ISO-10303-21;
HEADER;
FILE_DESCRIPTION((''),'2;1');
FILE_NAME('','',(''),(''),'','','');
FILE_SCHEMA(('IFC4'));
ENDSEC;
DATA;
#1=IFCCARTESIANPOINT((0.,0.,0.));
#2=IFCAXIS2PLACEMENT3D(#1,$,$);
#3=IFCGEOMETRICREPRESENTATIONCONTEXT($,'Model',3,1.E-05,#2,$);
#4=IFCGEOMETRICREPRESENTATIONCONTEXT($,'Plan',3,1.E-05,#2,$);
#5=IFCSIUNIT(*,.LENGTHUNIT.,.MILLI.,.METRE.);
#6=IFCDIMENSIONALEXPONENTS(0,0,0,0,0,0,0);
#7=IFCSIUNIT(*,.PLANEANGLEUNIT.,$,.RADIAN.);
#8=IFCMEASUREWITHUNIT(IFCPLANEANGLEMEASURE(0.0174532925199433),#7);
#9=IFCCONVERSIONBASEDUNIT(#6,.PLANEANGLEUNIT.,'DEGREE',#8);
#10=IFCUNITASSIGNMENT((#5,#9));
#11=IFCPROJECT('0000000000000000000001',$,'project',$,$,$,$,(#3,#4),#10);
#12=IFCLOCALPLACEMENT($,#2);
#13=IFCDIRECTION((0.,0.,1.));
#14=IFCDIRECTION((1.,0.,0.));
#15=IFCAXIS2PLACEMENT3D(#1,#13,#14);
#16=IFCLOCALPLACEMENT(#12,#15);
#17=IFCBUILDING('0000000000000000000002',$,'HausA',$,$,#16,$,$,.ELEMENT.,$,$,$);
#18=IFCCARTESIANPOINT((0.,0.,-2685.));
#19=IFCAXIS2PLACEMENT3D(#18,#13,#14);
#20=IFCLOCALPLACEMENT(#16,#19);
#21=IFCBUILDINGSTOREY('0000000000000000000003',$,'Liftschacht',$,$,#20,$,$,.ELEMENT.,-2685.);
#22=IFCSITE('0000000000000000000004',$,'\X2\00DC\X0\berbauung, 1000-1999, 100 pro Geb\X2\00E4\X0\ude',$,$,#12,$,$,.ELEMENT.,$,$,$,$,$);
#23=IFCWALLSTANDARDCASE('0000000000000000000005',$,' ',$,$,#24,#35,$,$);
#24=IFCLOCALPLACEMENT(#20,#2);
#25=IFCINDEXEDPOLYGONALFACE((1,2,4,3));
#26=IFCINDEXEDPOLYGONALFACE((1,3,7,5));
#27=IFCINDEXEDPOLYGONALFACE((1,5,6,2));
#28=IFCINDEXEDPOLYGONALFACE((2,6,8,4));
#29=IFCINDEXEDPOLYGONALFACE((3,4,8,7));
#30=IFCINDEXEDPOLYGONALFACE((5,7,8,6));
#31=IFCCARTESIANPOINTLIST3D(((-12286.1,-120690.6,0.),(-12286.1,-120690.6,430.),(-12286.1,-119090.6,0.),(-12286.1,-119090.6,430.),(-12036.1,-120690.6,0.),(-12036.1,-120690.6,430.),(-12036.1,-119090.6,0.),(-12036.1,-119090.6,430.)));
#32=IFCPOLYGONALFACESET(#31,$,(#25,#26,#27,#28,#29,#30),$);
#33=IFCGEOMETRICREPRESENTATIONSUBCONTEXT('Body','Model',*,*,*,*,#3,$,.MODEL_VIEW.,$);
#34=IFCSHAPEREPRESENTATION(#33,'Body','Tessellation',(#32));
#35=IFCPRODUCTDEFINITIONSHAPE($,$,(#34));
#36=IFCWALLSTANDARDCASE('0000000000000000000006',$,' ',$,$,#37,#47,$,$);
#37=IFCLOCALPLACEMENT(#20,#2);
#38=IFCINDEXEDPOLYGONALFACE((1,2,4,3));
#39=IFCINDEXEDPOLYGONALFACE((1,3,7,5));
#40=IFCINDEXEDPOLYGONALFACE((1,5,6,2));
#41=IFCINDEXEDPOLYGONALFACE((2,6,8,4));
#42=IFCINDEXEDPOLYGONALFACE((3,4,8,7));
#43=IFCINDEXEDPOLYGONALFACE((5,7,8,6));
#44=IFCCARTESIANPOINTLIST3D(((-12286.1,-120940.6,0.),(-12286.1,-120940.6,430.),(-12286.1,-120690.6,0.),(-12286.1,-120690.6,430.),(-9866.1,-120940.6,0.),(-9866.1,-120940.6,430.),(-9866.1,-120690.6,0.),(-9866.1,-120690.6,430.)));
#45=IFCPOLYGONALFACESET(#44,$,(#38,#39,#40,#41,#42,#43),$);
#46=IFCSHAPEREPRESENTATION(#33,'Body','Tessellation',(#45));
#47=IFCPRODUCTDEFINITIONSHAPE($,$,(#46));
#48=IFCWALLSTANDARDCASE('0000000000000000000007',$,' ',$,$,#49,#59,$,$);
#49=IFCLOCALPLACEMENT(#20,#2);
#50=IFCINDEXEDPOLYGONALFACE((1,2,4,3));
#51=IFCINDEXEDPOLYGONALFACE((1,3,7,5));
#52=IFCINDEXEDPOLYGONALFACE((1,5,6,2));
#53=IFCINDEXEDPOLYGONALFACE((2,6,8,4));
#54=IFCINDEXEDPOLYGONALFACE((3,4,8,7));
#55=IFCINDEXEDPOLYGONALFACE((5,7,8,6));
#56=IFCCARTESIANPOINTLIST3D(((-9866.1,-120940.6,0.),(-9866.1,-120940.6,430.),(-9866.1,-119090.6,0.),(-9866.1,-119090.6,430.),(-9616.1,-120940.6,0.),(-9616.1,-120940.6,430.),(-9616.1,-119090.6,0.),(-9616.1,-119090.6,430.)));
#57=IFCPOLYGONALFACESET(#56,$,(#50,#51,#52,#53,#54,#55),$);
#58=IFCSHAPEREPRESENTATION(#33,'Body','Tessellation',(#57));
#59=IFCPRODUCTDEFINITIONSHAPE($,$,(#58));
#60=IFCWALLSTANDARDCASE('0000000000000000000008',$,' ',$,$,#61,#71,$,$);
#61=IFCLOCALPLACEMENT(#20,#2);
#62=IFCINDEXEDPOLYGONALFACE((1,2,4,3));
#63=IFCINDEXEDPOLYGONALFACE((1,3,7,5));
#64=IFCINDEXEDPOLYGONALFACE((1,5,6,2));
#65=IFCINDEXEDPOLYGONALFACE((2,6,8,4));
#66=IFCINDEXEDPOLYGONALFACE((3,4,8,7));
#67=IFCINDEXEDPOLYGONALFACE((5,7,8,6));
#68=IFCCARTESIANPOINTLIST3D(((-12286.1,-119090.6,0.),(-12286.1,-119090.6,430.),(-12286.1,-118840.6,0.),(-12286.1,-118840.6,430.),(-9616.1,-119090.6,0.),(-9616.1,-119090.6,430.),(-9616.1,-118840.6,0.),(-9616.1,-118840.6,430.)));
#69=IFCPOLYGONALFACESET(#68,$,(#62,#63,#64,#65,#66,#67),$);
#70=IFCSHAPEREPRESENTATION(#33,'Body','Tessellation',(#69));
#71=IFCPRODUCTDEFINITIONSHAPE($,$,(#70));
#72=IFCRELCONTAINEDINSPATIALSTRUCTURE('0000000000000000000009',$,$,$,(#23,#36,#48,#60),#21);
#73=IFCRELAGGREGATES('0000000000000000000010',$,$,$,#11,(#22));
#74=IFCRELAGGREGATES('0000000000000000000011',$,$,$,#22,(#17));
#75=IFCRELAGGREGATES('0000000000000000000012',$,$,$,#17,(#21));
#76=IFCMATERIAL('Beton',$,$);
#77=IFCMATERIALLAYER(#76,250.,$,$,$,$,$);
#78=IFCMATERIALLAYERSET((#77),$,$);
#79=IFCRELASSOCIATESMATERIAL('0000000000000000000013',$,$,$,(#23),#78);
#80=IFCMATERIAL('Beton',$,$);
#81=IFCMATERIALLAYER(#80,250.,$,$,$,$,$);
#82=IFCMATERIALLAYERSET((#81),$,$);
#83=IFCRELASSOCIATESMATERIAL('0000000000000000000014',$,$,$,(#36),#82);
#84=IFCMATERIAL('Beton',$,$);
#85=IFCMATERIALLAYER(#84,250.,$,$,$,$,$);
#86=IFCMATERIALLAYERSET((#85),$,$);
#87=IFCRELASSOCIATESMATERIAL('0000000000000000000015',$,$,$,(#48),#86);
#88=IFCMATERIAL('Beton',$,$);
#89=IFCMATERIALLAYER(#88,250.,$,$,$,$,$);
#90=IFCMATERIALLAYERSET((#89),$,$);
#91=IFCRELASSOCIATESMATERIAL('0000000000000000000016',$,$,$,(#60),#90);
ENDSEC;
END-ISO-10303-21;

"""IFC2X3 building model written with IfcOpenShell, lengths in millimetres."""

from ifc_helpers import new_model, entity, si_unit, converted_unit, frame, frame_2d, origin, origin_with_axes, place, context, subcontext, project, spatial, rectangle, extrude, material, layer, layer_set, layer_usage, element, save


model = new_model("IFC2X3")

# Units and contexts
model_context = context("Model", 3, precision=1e-05, world=origin())
plan_context = context("Plan", 3, precision=1e-05, world=origin())
body_context = subcontext(model_context, "Body", "Model", "MODEL_VIEW")
ifc_project = project(units=[si_unit("LENGTHUNIT", "METRE", prefix="MILLI"), converted_unit("PLANEANGLEUNIT", "DEGREE", entity("IfcPlaneAngleMeasure", 0.0174532925199433), si_unit("PLANEANGLEUNIT", "RADIAN"), dimensions=[0, 0, 0, 0, 0, 0, 0])], contexts=[model_context, plan_context])

# Site, building, storey
site_placement = place(None, origin())
site = spatial("IfcSite", under=ifc_project, at=site_placement, Name="Überbauung, 1000-1999, 100 pro Gebäude", CompositionType="ELEMENT")
building_placement = place(site_placement, origin_with_axes())
building = spatial("IfcBuilding", under=site, at=building_placement, Name="HausA", CompositionType="ELEMENT")
storey_placement = place(building_placement, frame((0.0, 0.0, -2685.0), z_axis=(0.0, 0.0, 1.0), x_axis=(1.0, 0.0, 0.0)))
storey = spatial("IfcBuildingStorey", under=building, at=storey_placement, Name="Liftschacht", CompositionType="ELEMENT", Elevation=-2685.0)

# Walls
ifc_material_1 = material(Name="Beton")
ifc_layer_1 = layer(ifc_material_1, 250.0)
ifc_layer_set_1 = layer_set([ifc_layer_1])
ifc_layer_usage_1 = layer_usage(ifc_layer_set_1, "AXIS2", "POSITIVE", 0.0)
wall_1_placement = place(storey_placement, frame((-12286.1, -119090.6, 0.0), z_axis=(0.0, 0.0, 1.0), x_axis=(0.0, -1.0, 0.0)))
element("IfcWallStandardCase", 1, at=wall_1_placement, inside=storey, material=ifc_layer_usage_1, Name=" ", context=body_context, shape_type="SweptSolid", body=[
    extrude(rectangle(XDim=1600.0, YDim=250.0, at=frame_2d((800.0, 125.0), x_axis=(1.0, 0.0))), origin_with_axes(), (0.0, 0.0, 1.0), 430.0),
])
ifc_material_2 = material(Name="Beton")
ifc_layer_2 = layer(ifc_material_2, 250.0)
ifc_layer_set_2 = layer_set([ifc_layer_2])
ifc_layer_usage_2 = layer_usage(ifc_layer_set_2, "AXIS2", "POSITIVE", 0.0)
wall_2_placement = place(storey_placement, frame((-12286.1, -120940.6, 0.0), z_axis=(0.0, 0.0, 1.0), x_axis=(1.0, 0.0, 0.0)))
element("IfcWallStandardCase", 2, at=wall_2_placement, inside=storey, material=ifc_layer_usage_2, Name=" ", context=body_context, shape_type="SweptSolid", body=[
    extrude(rectangle(XDim=2420.0, YDim=250.0, at=frame_2d((1210.0, 125.0), x_axis=(1.0, 0.0))), origin_with_axes(), (0.0, 0.0, 1.0), 430.0),
])
ifc_material_3 = material(Name="Beton")
ifc_layer_3 = layer(ifc_material_3, 250.0)
ifc_layer_set_3 = layer_set([ifc_layer_3])
ifc_layer_usage_3 = layer_usage(ifc_layer_set_3, "AXIS2", "POSITIVE", 0.0)
wall_3_placement = place(storey_placement, frame((-9616.1, -120940.6, 0.0), z_axis=(0.0, 0.0, 1.0), x_axis=(0.0, 1.0, 0.0)))
element("IfcWallStandardCase", 3, at=wall_3_placement, inside=storey, material=ifc_layer_usage_3, Name=" ", context=body_context, shape_type="SweptSolid", body=[
    extrude(rectangle(XDim=1850.0, YDim=250.0, at=frame_2d((925.0, 125.0), x_axis=(1.0, 0.0))), origin_with_axes(), (0.0, 0.0, 1.0), 430.0),
])
ifc_material_4 = material(Name="Beton")
ifc_layer_4 = layer(ifc_material_4, 250.0)
ifc_layer_set_4 = layer_set([ifc_layer_4])
ifc_layer_usage_4 = layer_usage(ifc_layer_set_4, "AXIS2", "POSITIVE", 0.0)
wall_4_placement = place(storey_placement, frame((-9616.1, -118840.6, 0.0), z_axis=(0.0, 0.0, 1.0), x_axis=(-1.0, 0.0, 0.0)))
element("IfcWallStandardCase", 4, at=wall_4_placement, inside=storey, material=ifc_layer_usage_4, Name=" ", context=body_context, shape_type="SweptSolid", body=[
    extrude(rectangle(XDim=2670.0, YDim=250.0, at=frame_2d((1335.0, 125.0), x_axis=(1.0, 0.0))), origin_with_axes(), (0.0, 0.0, 1.0), 430.0),
])

save(model, "model.ifc")
